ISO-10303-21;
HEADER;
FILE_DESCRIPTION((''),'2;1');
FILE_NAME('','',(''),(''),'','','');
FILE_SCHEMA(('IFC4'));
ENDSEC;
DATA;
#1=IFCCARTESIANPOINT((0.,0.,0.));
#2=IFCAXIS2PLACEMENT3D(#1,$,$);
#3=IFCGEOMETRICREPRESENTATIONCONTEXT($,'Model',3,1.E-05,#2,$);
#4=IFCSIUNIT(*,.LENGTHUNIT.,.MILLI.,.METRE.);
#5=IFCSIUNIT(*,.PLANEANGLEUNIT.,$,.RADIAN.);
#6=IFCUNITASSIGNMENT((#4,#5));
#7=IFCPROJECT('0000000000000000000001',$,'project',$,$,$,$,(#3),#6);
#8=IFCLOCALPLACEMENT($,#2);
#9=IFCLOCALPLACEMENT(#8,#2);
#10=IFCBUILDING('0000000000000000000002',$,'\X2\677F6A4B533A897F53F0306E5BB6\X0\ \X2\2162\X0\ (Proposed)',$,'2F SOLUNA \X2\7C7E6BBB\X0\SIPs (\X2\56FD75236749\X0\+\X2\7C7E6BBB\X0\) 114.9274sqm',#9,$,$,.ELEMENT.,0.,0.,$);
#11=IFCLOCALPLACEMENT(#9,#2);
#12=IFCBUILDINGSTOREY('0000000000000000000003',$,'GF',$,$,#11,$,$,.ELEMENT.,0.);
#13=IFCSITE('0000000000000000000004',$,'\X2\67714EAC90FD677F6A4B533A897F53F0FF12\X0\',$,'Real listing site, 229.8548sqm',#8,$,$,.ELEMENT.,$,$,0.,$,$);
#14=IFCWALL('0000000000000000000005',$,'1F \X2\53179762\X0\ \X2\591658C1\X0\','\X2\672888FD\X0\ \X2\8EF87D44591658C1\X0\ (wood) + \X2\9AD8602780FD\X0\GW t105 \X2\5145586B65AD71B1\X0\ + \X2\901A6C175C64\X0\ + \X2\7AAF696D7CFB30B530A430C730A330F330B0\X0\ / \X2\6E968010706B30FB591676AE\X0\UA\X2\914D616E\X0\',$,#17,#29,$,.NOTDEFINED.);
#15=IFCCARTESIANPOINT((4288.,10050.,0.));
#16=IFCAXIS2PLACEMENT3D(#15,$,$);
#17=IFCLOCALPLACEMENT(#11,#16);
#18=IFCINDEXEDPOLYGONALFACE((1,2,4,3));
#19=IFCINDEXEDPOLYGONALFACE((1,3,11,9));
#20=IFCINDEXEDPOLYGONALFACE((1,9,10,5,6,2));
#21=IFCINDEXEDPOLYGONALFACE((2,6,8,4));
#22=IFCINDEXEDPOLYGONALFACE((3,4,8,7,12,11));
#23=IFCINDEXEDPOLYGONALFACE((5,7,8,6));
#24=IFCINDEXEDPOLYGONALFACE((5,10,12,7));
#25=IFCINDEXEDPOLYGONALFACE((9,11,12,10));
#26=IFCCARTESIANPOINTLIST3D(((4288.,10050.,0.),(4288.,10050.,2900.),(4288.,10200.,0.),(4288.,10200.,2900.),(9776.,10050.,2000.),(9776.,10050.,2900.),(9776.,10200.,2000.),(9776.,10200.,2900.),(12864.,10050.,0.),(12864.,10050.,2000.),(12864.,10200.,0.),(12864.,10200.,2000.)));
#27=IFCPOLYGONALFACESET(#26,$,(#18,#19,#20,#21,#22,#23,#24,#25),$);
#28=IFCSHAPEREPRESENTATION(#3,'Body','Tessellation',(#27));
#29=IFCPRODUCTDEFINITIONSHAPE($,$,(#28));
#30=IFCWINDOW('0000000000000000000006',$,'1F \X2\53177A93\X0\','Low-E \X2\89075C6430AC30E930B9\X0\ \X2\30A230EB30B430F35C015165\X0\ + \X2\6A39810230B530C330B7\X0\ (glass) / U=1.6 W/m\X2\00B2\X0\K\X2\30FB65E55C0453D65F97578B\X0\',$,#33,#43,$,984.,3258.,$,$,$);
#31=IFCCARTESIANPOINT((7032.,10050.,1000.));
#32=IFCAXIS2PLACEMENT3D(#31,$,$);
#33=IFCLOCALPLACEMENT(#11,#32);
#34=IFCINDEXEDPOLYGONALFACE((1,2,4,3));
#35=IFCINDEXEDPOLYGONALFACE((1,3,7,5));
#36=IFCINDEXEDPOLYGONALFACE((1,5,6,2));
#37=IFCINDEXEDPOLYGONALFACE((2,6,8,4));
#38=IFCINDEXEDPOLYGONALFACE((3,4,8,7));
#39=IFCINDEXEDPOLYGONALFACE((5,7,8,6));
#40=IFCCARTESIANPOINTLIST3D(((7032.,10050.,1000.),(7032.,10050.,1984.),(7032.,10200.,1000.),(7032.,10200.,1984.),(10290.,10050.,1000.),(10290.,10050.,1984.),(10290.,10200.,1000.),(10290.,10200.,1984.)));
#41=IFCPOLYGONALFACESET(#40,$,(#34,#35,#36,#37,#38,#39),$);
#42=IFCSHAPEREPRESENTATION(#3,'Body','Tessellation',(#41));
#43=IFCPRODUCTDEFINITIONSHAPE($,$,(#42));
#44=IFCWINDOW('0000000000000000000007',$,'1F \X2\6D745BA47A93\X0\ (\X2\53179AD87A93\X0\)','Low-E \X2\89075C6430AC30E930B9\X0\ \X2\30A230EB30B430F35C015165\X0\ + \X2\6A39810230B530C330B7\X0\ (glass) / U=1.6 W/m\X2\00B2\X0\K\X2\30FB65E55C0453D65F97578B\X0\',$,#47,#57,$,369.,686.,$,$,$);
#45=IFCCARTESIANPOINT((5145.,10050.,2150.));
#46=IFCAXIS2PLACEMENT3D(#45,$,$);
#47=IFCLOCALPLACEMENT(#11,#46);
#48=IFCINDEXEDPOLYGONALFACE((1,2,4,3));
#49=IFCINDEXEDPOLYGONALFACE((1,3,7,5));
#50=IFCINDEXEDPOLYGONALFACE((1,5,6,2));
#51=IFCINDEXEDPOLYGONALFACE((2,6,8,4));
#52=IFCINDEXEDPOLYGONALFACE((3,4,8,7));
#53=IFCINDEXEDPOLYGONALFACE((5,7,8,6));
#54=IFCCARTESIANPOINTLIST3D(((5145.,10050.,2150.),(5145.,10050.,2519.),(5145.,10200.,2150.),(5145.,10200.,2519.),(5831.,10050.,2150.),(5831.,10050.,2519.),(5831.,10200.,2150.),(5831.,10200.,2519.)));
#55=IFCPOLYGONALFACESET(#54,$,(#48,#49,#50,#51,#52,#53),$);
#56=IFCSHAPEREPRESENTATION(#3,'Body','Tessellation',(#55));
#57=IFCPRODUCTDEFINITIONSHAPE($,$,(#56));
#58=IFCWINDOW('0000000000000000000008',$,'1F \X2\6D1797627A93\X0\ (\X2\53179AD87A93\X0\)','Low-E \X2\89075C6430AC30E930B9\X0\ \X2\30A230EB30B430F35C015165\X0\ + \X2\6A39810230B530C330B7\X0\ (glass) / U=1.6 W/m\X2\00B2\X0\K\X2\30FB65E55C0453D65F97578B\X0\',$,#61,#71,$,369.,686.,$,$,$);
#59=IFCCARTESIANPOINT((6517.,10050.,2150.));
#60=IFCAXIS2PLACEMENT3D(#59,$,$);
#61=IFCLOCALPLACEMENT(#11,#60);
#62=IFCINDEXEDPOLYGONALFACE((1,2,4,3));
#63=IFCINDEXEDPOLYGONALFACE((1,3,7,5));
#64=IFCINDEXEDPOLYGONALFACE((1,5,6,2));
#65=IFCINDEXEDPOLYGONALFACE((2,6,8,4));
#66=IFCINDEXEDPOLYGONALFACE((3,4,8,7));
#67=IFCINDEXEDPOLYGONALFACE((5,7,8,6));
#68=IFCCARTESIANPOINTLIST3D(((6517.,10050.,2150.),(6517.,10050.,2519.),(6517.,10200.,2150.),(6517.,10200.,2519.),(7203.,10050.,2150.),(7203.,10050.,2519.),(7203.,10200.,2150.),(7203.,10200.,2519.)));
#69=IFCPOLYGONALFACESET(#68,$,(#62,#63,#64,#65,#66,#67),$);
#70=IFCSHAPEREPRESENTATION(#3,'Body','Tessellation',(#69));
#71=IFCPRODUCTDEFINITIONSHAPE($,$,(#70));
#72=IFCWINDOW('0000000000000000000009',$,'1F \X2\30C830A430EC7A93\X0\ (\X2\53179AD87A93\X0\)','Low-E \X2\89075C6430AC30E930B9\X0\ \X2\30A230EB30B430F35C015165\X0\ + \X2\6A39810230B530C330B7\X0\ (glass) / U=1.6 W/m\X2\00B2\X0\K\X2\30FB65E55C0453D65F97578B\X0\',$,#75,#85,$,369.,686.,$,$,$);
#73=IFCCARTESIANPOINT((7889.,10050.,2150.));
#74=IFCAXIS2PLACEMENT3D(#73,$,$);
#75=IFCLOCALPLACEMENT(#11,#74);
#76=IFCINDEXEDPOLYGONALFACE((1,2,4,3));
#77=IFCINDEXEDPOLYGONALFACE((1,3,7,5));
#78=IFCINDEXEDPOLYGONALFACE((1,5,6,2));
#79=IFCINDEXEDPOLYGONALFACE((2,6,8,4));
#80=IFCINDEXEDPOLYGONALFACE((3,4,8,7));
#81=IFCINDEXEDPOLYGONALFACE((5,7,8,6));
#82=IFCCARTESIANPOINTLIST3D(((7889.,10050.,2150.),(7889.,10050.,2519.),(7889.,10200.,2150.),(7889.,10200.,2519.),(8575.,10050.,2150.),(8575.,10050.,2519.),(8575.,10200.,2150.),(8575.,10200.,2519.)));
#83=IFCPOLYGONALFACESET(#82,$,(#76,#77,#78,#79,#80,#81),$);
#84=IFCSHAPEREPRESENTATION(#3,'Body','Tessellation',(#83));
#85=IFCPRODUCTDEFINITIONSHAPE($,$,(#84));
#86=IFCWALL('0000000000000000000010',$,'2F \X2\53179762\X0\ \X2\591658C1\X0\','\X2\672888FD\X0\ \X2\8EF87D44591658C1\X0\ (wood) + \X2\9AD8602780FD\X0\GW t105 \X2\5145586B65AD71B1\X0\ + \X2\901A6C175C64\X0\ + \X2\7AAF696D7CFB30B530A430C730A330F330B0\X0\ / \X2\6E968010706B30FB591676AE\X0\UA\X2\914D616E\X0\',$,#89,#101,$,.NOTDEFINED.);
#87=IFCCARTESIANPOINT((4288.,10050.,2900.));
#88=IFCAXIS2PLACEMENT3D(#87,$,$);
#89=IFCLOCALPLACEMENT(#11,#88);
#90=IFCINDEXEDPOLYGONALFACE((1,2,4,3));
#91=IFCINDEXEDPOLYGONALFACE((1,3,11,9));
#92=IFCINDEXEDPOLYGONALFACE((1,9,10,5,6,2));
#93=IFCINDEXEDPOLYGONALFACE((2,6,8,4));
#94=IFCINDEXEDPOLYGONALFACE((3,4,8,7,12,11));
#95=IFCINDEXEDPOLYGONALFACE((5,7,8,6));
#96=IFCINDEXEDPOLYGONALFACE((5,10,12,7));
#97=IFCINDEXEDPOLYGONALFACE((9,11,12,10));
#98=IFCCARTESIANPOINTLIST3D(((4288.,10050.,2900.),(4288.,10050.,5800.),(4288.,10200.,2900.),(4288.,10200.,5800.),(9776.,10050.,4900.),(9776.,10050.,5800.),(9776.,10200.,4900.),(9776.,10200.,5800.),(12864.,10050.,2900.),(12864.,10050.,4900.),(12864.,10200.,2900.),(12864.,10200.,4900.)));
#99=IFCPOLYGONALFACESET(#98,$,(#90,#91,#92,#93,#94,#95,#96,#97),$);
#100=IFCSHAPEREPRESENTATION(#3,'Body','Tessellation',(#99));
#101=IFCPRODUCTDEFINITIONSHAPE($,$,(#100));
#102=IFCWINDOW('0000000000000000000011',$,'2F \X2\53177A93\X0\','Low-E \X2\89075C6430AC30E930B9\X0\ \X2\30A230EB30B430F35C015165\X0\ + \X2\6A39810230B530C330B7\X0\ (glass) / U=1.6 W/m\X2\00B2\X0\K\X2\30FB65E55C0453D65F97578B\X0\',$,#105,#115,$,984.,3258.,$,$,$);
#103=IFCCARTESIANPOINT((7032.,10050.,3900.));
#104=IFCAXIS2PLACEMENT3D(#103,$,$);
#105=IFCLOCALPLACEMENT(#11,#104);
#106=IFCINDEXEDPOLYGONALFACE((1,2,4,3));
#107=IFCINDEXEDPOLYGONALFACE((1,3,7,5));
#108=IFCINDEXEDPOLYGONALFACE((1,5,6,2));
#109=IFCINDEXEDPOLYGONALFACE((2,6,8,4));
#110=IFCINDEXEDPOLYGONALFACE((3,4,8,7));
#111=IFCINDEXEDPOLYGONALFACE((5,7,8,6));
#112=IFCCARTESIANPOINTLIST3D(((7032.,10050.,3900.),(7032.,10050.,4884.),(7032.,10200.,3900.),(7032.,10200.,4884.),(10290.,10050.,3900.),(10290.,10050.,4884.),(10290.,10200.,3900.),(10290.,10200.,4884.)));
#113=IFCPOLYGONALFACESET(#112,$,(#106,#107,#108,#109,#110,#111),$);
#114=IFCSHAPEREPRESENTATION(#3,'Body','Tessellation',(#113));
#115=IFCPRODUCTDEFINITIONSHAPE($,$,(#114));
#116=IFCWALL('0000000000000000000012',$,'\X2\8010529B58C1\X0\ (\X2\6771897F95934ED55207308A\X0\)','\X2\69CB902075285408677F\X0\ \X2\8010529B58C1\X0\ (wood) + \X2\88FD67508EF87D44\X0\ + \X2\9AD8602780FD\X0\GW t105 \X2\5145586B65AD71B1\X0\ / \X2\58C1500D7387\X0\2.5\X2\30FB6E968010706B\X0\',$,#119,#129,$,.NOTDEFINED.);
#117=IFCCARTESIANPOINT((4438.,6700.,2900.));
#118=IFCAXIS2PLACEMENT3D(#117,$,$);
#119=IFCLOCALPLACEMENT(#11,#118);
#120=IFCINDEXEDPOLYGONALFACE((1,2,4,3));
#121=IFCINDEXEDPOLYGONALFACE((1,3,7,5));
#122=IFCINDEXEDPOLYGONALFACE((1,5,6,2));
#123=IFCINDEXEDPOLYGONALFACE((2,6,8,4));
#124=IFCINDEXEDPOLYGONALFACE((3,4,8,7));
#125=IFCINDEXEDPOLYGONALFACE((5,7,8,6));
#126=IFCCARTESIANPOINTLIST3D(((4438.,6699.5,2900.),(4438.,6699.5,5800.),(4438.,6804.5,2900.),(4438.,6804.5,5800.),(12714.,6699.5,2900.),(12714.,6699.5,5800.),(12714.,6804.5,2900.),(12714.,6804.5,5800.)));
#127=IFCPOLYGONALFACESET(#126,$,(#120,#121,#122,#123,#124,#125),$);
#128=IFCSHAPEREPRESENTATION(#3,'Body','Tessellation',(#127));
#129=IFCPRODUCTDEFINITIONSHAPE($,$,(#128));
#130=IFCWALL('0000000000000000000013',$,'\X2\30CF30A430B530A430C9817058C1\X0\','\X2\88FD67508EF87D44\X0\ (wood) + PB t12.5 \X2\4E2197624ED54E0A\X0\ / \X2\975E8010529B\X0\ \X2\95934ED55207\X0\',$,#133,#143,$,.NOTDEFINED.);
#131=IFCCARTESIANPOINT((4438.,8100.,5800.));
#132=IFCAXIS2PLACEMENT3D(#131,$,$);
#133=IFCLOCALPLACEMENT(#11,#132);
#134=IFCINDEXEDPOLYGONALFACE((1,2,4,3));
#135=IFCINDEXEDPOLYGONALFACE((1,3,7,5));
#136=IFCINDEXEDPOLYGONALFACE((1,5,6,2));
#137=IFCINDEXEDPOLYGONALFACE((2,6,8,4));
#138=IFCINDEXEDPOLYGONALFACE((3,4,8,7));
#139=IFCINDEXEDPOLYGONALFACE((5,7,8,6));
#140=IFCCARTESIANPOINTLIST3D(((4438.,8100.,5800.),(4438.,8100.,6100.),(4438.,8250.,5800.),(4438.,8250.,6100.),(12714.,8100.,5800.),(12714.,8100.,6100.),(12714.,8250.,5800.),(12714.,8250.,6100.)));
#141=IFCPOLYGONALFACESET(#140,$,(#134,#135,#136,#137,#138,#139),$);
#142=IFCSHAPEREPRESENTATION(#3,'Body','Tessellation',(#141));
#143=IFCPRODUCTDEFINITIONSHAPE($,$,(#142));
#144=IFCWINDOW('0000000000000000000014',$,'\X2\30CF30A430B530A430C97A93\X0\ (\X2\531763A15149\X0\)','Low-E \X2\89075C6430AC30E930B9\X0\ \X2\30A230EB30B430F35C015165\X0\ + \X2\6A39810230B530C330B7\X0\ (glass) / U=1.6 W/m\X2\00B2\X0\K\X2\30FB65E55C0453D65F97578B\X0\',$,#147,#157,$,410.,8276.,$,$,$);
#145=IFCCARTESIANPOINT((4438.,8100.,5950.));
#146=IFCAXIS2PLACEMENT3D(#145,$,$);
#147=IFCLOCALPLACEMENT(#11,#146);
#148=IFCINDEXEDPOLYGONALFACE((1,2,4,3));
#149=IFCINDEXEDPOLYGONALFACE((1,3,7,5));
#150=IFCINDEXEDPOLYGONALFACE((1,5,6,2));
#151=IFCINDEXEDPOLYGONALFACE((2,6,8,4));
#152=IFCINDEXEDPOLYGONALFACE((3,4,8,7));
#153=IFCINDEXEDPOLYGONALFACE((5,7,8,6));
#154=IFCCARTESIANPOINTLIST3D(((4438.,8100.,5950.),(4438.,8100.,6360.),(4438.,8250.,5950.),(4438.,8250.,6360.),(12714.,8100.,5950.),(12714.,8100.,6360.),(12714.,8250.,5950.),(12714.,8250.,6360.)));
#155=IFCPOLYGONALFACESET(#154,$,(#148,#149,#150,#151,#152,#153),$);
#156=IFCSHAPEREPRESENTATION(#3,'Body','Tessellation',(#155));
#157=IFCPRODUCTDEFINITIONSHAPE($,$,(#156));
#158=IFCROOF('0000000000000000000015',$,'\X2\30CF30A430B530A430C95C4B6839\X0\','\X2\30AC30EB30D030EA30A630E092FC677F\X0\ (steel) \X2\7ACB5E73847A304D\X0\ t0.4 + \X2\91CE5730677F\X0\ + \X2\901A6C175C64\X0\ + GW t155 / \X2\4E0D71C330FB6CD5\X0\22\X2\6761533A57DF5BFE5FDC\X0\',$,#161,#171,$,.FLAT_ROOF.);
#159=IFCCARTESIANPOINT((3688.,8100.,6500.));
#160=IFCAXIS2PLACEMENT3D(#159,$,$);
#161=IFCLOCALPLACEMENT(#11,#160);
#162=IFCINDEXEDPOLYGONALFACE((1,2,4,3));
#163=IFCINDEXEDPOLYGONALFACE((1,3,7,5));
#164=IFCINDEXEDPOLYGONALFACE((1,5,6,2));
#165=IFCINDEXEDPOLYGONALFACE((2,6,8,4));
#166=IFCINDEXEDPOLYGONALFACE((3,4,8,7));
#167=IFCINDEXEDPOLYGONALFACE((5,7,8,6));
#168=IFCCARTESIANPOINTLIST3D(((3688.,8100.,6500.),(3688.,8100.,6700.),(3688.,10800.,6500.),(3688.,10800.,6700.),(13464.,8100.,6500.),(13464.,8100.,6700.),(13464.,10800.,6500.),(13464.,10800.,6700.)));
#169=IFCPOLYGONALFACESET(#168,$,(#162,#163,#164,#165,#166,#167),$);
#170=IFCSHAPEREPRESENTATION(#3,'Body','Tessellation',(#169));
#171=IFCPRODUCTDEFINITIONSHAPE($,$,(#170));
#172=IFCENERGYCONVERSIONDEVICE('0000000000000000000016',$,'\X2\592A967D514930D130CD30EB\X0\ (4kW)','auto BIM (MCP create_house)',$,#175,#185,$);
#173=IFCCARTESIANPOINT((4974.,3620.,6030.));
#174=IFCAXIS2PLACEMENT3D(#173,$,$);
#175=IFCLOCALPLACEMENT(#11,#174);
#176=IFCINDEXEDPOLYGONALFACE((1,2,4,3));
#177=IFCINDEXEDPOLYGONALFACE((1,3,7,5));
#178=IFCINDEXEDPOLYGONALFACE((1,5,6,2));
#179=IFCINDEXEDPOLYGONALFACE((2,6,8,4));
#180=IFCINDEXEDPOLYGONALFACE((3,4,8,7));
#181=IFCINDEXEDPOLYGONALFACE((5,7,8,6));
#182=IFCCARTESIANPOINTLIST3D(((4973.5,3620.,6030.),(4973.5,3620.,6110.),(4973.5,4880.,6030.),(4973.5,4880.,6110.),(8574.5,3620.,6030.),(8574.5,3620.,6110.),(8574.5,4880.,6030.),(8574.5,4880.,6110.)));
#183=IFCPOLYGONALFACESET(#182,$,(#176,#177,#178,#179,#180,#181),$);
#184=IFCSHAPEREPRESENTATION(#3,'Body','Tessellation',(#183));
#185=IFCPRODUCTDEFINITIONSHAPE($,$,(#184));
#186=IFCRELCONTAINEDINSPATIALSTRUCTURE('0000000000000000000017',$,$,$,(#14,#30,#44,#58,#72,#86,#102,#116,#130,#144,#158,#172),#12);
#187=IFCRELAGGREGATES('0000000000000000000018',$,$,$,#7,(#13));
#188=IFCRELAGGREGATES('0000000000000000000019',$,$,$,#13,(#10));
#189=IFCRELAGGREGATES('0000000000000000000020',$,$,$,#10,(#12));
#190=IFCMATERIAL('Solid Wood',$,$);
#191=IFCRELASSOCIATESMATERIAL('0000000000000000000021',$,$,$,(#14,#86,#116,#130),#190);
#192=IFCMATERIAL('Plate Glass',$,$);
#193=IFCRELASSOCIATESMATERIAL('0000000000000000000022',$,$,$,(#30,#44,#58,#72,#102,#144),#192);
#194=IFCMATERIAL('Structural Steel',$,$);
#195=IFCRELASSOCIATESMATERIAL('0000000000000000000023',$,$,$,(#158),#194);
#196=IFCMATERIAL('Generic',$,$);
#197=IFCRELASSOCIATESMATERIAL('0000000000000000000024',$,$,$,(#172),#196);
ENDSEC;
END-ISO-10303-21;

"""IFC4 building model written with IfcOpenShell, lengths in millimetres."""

from ifc_helpers import new_model, si_unit, frame, frame_2d, origin, place, context, project, spatial, rectangle, extrude, material, element, fill, save


model = new_model("IFC4")

# Units and contexts
model_context = context("Model", 3, precision=1e-05, world=origin())
ifc_project = project(units=[si_unit("LENGTHUNIT", "METRE", prefix="MILLI"), si_unit("PLANEANGLEUNIT", "RADIAN")], contexts=[model_context])

# Site, building, storey
site_placement = place(None, origin())
site = spatial("IfcSite", under=ifc_project, at=site_placement, Name="東京都板橋区西台２", ObjectType="Real listing site, 229.8548sqm", CompositionType="ELEMENT", RefElevation=0.0)
building_placement = place(site_placement, origin())
building = spatial("IfcBuilding", under=site, at=building_placement, Name="板橋区西台の家 Ⅲ (Proposed)", ObjectType="2F SOLUNA 籾殻SIPs (国産杉+籾殻) 114.9274sqm", CompositionType="ELEMENT", ElevationOfRefHeight=0.0, ElevationOfTerrain=0.0)
storey_placement = place(building_placement, origin())
storey = spatial("IfcBuildingStorey", under=building, at=storey_placement, Name="GF", CompositionType="ELEMENT", Elevation=0.0)

# Wall, openings, windows
ifc_material_1 = material(Name="Solid Wood")
wall_1_placement = place(storey_placement, frame((4288.0, 10050.0, 0.0)))
wall_1 = element("IfcWall", 1, at=wall_1_placement, inside=storey, material=ifc_material_1, Name="1F 北面 外壁", Description="木製 軸組外壁 (wood) + 高性能GW t105 充填断熱 + 通気層 + 窯業系サイディング / 準耐火・外皮UA配慮", PredefinedType="NOTDEFINED", context=model_context, shape_type="SweptSolid", body=[
    extrude(rectangle(XDim=8576.0, YDim=150.0, at=frame_2d((4288.0, 75.0))), frame((4288.0, 10050.0, 0.0)), (0.0, 0.0, 1.0), 2900.0),
])
opening_1_placement = place(storey_placement, frame((7032.0, 10050.0, 1000.0)))
opening_1 = element("IfcOpeningElement", 2, at=opening_1_placement, cuts=wall_1, PredefinedType="NOTDEFINED", context=model_context, shape_type="SweptSolid", body=[
    extrude(rectangle(XDim=3258.0, YDim=150.0, at=frame_2d((1629.0, 75.0))), frame((7032.0, 10050.0, 1000.0)), (0.0, 0.0, 1.0), 984.0),
])
opening_2_placement = place(storey_placement, frame((5145.0, 10050.0, 2150.0)))
opening_2 = element("IfcOpeningElement", 3, at=opening_2_placement, cuts=wall_1, PredefinedType="NOTDEFINED", context=model_context, shape_type="SweptSolid", body=[
    extrude(rectangle(XDim=686.0, YDim=150.0, at=frame_2d((343.0, 75.0))), frame((5145.0, 10050.0, 2150.0)), (0.0, 0.0, 1.0), 369.0),
])
opening_3_placement = place(storey_placement, frame((6517.0, 10050.0, 2150.0)))
opening_3 = element("IfcOpeningElement", 4, at=opening_3_placement, cuts=wall_1, PredefinedType="NOTDEFINED", context=model_context, shape_type="SweptSolid", body=[
    extrude(rectangle(XDim=686.0, YDim=150.0, at=frame_2d((343.0, 75.0))), frame((6517.0, 10050.0, 2150.0)), (0.0, 0.0, 1.0), 369.0),
])
opening_4_placement = place(storey_placement, frame((7889.0, 10050.0, 2150.0)))
opening_4 = element("IfcOpeningElement", 5, at=opening_4_placement, cuts=wall_1, PredefinedType="NOTDEFINED", context=model_context, shape_type="SweptSolid", body=[
    extrude(rectangle(XDim=686.0, YDim=150.0, at=frame_2d((343.0, 75.0))), frame((7889.0, 10050.0, 2150.0)), (0.0, 0.0, 1.0), 369.0),
])
ifc_material_2 = material(Name="Plate Glass")
window_1_placement = place(storey_placement, frame((7032.0, 10050.0, 1000.0)))
window_1 = element("IfcWindow", 6, at=window_1_placement, inside=storey, material=ifc_material_2, Name="1F 北窓", Description="Low-E 複層ガラス アルゴン封入 + 樹脂サッシ (glass) / U=1.6 W/m²K・日射取得型", OverallHeight=984.0, OverallWidth=3258.0, context=model_context, shape_type="SweptSolid", body=[
    extrude(rectangle(XDim=3258.0, YDim=150.0, at=frame_2d((1629.0, 75.0))), frame((7032.0, 10050.0, 1000.0)), (0.0, 0.0, 1.0), 984.0),
])
fill(opening_1, window_1)
window_2_placement = place(storey_placement, frame((5145.0, 10050.0, 2150.0)))
window_2 = element("IfcWindow", 7, at=window_2_placement, inside=storey, material=ifc_material_2, Name="1F 浴室窓 (北高窓)", Description="Low-E 複層ガラス アルゴン封入 + 樹脂サッシ (glass) / U=1.6 W/m²K・日射取得型", OverallHeight=369.0, OverallWidth=686.0, context=model_context, shape_type="SweptSolid", body=[
    extrude(rectangle(XDim=686.0, YDim=150.0, at=frame_2d((343.0, 75.0))), frame((5145.0, 10050.0, 2150.0)), (0.0, 0.0, 1.0), 369.0),
])
fill(opening_2, window_2)
window_3_placement = place(storey_placement, frame((6517.0, 10050.0, 2150.0)))
window_3 = element("IfcWindow", 8, at=window_3_placement, inside=storey, material=ifc_material_2, Name="1F 洗面窓 (北高窓)", Description="Low-E 複層ガラス アルゴン封入 + 樹脂サッシ (glass) / U=1.6 W/m²K・日射取得型", OverallHeight=369.0, OverallWidth=686.0, context=model_context, shape_type="SweptSolid", body=[
    extrude(rectangle(XDim=686.0, YDim=150.0, at=frame_2d((343.0, 75.0))), frame((6517.0, 10050.0, 2150.0)), (0.0, 0.0, 1.0), 369.0),
])
fill(opening_3, window_3)
window_4_placement = place(storey_placement, frame((7889.0, 10050.0, 2150.0)))
window_4 = element("IfcWindow", 9, at=window_4_placement, inside=storey, material=ifc_material_2, Name="1F トイレ窓 (北高窓)", Description="Low-E 複層ガラス アルゴン封入 + 樹脂サッシ (glass) / U=1.6 W/m²K・日射取得型", OverallHeight=369.0, OverallWidth=686.0, context=model_context, shape_type="SweptSolid", body=[
    extrude(rectangle(XDim=686.0, YDim=150.0, at=frame_2d((343.0, 75.0))), frame((7889.0, 10050.0, 2150.0)), (0.0, 0.0, 1.0), 369.0),
])
fill(opening_4, window_4)

# Wall, opening, window
wall_2_placement = place(storey_placement, frame((4288.0, 10050.0, 2900.0)))
wall_2 = element("IfcWall", 10, at=wall_2_placement, inside=storey, material=ifc_material_1, Name="2F 北面 外壁", Description="木製 軸組外壁 (wood) + 高性能GW t105 充填断熱 + 通気層 + 窯業系サイディング / 準耐火・外皮UA配慮", PredefinedType="NOTDEFINED", context=model_context, shape_type="SweptSolid", body=[
    extrude(rectangle(XDim=8576.0, YDim=150.0, at=frame_2d((4288.0, 75.0))), frame((4288.0, 10050.0, 2900.0)), (0.0, 0.0, 1.0), 2900.0),
])
opening_5_placement = place(storey_placement, frame((7032.0, 10050.0, 3900.0)))
opening_5 = element("IfcOpeningElement", 11, at=opening_5_placement, cuts=wall_2, PredefinedType="NOTDEFINED", context=model_context, shape_type="SweptSolid", body=[
    extrude(rectangle(XDim=3258.0, YDim=150.0, at=frame_2d((1629.0, 75.0))), frame((7032.0, 10050.0, 3900.0)), (0.0, 0.0, 1.0), 984.0),
])
window_5_placement = place(storey_placement, frame((7032.0, 10050.0, 3900.0)))
window_5 = element("IfcWindow", 12, at=window_5_placement, inside=storey, material=ifc_material_2, Name="2F 北窓", Description="Low-E 複層ガラス アルゴン封入 + 樹脂サッシ (glass) / U=1.6 W/m²K・日射取得型", OverallHeight=984.0, OverallWidth=3258.0, context=model_context, shape_type="SweptSolid", body=[
    extrude(rectangle(XDim=3258.0, YDim=150.0, at=frame_2d((1629.0, 75.0))), frame((7032.0, 10050.0, 3900.0)), (0.0, 0.0, 1.0), 984.0),
])
fill(opening_5, window_5)

# Wall
wall_3_placement = place(storey_placement, frame((4438.0, 6700.0, 2900.0)))
element("IfcWall", 13, at=wall_3_placement, inside=storey, material=ifc_material_1, Name="耐力壁 (東西間仕切り)", Description="構造用合板 耐力壁 (wood) + 製材軸組 + 高性能GW t105 充填断熱 / 壁倍率2.5・準耐火", PredefinedType="NOTDEFINED", context=model_context, shape_type="SweptSolid", body=[
    extrude(rectangle(XDim=8276.0, YDim=105.0, at=frame_2d((4138.0, 52.0))), frame((4438.0, 6700.0, 2900.0)), (0.0, 0.0, 1.0), 2900.0),
])

# Wall, opening, window
wall_4_placement = place(storey_placement, frame((4438.0, 8100.0, 5800.0)))
wall_4 = element("IfcWall", 14, at=wall_4_placement, inside=storey, material=ifc_material_1, Name="ハイサイド腰壁", Description="製材軸組 (wood) + PB t12.5 両面仕上 / 非耐力 間仕切", PredefinedType="NOTDEFINED", context=model_context, shape_type="SweptSolid", body=[
    extrude(rectangle(XDim=8276.0, YDim=150.0, at=frame_2d((4138.0, 75.0))), frame((4438.0, 8100.0, 5800.0)), (0.0, 0.0, 1.0), 700.0),
])
opening_6_placement = place(storey_placement, frame((4438.0, 8100.0, 5950.0)))
opening_6 = element("IfcOpeningElement", 15, at=opening_6_placement, cuts=wall_4, PredefinedType="NOTDEFINED", context=model_context, shape_type="SweptSolid", body=[
    extrude(rectangle(XDim=8276.0, YDim=150.0, at=frame_2d((4138.0, 75.0))), frame((4438.0, 8100.0, 5950.0)), (0.0, 0.0, 1.0), 410.0),
])
window_6_placement = place(storey_placement, frame((4438.0, 8100.0, 5950.0)))
window_6 = element("IfcWindow", 16, at=window_6_placement, inside=storey, material=ifc_material_2, Name="ハイサイド窓 (北採光)", Description="Low-E 複層ガラス アルゴン封入 + 樹脂サッシ (glass) / U=1.6 W/m²K・日射取得型", OverallHeight=410.0, OverallWidth=8276.0, context=model_context, shape_type="SweptSolid", body=[
    extrude(rectangle(XDim=8276.0, YDim=150.0, at=frame_2d((4138.0, 75.0))), frame((4438.0, 8100.0, 5950.0)), (0.0, 0.0, 1.0), 410.0),
])
fill(opening_6, window_6)

# Roof
ifc_material_3 = material(Name="Structural Steel")
roof_placement = place(storey_placement, frame((3688.0, 8100.0, 6500.0)))
element("IfcRoof", 17, at=roof_placement, inside=storey, material=ifc_material_3, Name="ハイサイド屋根", Description="ガルバリウム鋼板 (steel) 立平葺き t0.4 + 野地板 + 通気層 + GW t155 / 不燃・法22条区域対応", PredefinedType="FLAT_ROOF", context=model_context, shape_type="SweptSolid", body=[
    extrude(rectangle(XDim=9776.0, YDim=2700.0, at=frame_2d((4888.0, 1350.0))), frame((3688.0, 8100.0, 6500.0)), (0.0, 0.0, 1.0), 200.0),
])

# Energy conversion device
ifc_material_4 = material(Name="Generic")
energy_conversion_device_placement = place(storey_placement, frame((4974.0, 3620.0, 6030.0)))
element("IfcEnergyConversionDevice", 18, at=energy_conversion_device_placement, inside=storey, material=ifc_material_4, Name="太陽光パネル (4kW)", Description="auto BIM (MCP create_house)", context=model_context, shape_type="SweptSolid", body=[
    extrude(rectangle(XDim=3601.0, YDim=1260.0, at=frame_2d((1800.0, 630.0))), frame((4974.0, 3620.0, 6030.0)), (0.0, 0.0, 1.0), 80.0),
])

save(model, "model.ifc")
